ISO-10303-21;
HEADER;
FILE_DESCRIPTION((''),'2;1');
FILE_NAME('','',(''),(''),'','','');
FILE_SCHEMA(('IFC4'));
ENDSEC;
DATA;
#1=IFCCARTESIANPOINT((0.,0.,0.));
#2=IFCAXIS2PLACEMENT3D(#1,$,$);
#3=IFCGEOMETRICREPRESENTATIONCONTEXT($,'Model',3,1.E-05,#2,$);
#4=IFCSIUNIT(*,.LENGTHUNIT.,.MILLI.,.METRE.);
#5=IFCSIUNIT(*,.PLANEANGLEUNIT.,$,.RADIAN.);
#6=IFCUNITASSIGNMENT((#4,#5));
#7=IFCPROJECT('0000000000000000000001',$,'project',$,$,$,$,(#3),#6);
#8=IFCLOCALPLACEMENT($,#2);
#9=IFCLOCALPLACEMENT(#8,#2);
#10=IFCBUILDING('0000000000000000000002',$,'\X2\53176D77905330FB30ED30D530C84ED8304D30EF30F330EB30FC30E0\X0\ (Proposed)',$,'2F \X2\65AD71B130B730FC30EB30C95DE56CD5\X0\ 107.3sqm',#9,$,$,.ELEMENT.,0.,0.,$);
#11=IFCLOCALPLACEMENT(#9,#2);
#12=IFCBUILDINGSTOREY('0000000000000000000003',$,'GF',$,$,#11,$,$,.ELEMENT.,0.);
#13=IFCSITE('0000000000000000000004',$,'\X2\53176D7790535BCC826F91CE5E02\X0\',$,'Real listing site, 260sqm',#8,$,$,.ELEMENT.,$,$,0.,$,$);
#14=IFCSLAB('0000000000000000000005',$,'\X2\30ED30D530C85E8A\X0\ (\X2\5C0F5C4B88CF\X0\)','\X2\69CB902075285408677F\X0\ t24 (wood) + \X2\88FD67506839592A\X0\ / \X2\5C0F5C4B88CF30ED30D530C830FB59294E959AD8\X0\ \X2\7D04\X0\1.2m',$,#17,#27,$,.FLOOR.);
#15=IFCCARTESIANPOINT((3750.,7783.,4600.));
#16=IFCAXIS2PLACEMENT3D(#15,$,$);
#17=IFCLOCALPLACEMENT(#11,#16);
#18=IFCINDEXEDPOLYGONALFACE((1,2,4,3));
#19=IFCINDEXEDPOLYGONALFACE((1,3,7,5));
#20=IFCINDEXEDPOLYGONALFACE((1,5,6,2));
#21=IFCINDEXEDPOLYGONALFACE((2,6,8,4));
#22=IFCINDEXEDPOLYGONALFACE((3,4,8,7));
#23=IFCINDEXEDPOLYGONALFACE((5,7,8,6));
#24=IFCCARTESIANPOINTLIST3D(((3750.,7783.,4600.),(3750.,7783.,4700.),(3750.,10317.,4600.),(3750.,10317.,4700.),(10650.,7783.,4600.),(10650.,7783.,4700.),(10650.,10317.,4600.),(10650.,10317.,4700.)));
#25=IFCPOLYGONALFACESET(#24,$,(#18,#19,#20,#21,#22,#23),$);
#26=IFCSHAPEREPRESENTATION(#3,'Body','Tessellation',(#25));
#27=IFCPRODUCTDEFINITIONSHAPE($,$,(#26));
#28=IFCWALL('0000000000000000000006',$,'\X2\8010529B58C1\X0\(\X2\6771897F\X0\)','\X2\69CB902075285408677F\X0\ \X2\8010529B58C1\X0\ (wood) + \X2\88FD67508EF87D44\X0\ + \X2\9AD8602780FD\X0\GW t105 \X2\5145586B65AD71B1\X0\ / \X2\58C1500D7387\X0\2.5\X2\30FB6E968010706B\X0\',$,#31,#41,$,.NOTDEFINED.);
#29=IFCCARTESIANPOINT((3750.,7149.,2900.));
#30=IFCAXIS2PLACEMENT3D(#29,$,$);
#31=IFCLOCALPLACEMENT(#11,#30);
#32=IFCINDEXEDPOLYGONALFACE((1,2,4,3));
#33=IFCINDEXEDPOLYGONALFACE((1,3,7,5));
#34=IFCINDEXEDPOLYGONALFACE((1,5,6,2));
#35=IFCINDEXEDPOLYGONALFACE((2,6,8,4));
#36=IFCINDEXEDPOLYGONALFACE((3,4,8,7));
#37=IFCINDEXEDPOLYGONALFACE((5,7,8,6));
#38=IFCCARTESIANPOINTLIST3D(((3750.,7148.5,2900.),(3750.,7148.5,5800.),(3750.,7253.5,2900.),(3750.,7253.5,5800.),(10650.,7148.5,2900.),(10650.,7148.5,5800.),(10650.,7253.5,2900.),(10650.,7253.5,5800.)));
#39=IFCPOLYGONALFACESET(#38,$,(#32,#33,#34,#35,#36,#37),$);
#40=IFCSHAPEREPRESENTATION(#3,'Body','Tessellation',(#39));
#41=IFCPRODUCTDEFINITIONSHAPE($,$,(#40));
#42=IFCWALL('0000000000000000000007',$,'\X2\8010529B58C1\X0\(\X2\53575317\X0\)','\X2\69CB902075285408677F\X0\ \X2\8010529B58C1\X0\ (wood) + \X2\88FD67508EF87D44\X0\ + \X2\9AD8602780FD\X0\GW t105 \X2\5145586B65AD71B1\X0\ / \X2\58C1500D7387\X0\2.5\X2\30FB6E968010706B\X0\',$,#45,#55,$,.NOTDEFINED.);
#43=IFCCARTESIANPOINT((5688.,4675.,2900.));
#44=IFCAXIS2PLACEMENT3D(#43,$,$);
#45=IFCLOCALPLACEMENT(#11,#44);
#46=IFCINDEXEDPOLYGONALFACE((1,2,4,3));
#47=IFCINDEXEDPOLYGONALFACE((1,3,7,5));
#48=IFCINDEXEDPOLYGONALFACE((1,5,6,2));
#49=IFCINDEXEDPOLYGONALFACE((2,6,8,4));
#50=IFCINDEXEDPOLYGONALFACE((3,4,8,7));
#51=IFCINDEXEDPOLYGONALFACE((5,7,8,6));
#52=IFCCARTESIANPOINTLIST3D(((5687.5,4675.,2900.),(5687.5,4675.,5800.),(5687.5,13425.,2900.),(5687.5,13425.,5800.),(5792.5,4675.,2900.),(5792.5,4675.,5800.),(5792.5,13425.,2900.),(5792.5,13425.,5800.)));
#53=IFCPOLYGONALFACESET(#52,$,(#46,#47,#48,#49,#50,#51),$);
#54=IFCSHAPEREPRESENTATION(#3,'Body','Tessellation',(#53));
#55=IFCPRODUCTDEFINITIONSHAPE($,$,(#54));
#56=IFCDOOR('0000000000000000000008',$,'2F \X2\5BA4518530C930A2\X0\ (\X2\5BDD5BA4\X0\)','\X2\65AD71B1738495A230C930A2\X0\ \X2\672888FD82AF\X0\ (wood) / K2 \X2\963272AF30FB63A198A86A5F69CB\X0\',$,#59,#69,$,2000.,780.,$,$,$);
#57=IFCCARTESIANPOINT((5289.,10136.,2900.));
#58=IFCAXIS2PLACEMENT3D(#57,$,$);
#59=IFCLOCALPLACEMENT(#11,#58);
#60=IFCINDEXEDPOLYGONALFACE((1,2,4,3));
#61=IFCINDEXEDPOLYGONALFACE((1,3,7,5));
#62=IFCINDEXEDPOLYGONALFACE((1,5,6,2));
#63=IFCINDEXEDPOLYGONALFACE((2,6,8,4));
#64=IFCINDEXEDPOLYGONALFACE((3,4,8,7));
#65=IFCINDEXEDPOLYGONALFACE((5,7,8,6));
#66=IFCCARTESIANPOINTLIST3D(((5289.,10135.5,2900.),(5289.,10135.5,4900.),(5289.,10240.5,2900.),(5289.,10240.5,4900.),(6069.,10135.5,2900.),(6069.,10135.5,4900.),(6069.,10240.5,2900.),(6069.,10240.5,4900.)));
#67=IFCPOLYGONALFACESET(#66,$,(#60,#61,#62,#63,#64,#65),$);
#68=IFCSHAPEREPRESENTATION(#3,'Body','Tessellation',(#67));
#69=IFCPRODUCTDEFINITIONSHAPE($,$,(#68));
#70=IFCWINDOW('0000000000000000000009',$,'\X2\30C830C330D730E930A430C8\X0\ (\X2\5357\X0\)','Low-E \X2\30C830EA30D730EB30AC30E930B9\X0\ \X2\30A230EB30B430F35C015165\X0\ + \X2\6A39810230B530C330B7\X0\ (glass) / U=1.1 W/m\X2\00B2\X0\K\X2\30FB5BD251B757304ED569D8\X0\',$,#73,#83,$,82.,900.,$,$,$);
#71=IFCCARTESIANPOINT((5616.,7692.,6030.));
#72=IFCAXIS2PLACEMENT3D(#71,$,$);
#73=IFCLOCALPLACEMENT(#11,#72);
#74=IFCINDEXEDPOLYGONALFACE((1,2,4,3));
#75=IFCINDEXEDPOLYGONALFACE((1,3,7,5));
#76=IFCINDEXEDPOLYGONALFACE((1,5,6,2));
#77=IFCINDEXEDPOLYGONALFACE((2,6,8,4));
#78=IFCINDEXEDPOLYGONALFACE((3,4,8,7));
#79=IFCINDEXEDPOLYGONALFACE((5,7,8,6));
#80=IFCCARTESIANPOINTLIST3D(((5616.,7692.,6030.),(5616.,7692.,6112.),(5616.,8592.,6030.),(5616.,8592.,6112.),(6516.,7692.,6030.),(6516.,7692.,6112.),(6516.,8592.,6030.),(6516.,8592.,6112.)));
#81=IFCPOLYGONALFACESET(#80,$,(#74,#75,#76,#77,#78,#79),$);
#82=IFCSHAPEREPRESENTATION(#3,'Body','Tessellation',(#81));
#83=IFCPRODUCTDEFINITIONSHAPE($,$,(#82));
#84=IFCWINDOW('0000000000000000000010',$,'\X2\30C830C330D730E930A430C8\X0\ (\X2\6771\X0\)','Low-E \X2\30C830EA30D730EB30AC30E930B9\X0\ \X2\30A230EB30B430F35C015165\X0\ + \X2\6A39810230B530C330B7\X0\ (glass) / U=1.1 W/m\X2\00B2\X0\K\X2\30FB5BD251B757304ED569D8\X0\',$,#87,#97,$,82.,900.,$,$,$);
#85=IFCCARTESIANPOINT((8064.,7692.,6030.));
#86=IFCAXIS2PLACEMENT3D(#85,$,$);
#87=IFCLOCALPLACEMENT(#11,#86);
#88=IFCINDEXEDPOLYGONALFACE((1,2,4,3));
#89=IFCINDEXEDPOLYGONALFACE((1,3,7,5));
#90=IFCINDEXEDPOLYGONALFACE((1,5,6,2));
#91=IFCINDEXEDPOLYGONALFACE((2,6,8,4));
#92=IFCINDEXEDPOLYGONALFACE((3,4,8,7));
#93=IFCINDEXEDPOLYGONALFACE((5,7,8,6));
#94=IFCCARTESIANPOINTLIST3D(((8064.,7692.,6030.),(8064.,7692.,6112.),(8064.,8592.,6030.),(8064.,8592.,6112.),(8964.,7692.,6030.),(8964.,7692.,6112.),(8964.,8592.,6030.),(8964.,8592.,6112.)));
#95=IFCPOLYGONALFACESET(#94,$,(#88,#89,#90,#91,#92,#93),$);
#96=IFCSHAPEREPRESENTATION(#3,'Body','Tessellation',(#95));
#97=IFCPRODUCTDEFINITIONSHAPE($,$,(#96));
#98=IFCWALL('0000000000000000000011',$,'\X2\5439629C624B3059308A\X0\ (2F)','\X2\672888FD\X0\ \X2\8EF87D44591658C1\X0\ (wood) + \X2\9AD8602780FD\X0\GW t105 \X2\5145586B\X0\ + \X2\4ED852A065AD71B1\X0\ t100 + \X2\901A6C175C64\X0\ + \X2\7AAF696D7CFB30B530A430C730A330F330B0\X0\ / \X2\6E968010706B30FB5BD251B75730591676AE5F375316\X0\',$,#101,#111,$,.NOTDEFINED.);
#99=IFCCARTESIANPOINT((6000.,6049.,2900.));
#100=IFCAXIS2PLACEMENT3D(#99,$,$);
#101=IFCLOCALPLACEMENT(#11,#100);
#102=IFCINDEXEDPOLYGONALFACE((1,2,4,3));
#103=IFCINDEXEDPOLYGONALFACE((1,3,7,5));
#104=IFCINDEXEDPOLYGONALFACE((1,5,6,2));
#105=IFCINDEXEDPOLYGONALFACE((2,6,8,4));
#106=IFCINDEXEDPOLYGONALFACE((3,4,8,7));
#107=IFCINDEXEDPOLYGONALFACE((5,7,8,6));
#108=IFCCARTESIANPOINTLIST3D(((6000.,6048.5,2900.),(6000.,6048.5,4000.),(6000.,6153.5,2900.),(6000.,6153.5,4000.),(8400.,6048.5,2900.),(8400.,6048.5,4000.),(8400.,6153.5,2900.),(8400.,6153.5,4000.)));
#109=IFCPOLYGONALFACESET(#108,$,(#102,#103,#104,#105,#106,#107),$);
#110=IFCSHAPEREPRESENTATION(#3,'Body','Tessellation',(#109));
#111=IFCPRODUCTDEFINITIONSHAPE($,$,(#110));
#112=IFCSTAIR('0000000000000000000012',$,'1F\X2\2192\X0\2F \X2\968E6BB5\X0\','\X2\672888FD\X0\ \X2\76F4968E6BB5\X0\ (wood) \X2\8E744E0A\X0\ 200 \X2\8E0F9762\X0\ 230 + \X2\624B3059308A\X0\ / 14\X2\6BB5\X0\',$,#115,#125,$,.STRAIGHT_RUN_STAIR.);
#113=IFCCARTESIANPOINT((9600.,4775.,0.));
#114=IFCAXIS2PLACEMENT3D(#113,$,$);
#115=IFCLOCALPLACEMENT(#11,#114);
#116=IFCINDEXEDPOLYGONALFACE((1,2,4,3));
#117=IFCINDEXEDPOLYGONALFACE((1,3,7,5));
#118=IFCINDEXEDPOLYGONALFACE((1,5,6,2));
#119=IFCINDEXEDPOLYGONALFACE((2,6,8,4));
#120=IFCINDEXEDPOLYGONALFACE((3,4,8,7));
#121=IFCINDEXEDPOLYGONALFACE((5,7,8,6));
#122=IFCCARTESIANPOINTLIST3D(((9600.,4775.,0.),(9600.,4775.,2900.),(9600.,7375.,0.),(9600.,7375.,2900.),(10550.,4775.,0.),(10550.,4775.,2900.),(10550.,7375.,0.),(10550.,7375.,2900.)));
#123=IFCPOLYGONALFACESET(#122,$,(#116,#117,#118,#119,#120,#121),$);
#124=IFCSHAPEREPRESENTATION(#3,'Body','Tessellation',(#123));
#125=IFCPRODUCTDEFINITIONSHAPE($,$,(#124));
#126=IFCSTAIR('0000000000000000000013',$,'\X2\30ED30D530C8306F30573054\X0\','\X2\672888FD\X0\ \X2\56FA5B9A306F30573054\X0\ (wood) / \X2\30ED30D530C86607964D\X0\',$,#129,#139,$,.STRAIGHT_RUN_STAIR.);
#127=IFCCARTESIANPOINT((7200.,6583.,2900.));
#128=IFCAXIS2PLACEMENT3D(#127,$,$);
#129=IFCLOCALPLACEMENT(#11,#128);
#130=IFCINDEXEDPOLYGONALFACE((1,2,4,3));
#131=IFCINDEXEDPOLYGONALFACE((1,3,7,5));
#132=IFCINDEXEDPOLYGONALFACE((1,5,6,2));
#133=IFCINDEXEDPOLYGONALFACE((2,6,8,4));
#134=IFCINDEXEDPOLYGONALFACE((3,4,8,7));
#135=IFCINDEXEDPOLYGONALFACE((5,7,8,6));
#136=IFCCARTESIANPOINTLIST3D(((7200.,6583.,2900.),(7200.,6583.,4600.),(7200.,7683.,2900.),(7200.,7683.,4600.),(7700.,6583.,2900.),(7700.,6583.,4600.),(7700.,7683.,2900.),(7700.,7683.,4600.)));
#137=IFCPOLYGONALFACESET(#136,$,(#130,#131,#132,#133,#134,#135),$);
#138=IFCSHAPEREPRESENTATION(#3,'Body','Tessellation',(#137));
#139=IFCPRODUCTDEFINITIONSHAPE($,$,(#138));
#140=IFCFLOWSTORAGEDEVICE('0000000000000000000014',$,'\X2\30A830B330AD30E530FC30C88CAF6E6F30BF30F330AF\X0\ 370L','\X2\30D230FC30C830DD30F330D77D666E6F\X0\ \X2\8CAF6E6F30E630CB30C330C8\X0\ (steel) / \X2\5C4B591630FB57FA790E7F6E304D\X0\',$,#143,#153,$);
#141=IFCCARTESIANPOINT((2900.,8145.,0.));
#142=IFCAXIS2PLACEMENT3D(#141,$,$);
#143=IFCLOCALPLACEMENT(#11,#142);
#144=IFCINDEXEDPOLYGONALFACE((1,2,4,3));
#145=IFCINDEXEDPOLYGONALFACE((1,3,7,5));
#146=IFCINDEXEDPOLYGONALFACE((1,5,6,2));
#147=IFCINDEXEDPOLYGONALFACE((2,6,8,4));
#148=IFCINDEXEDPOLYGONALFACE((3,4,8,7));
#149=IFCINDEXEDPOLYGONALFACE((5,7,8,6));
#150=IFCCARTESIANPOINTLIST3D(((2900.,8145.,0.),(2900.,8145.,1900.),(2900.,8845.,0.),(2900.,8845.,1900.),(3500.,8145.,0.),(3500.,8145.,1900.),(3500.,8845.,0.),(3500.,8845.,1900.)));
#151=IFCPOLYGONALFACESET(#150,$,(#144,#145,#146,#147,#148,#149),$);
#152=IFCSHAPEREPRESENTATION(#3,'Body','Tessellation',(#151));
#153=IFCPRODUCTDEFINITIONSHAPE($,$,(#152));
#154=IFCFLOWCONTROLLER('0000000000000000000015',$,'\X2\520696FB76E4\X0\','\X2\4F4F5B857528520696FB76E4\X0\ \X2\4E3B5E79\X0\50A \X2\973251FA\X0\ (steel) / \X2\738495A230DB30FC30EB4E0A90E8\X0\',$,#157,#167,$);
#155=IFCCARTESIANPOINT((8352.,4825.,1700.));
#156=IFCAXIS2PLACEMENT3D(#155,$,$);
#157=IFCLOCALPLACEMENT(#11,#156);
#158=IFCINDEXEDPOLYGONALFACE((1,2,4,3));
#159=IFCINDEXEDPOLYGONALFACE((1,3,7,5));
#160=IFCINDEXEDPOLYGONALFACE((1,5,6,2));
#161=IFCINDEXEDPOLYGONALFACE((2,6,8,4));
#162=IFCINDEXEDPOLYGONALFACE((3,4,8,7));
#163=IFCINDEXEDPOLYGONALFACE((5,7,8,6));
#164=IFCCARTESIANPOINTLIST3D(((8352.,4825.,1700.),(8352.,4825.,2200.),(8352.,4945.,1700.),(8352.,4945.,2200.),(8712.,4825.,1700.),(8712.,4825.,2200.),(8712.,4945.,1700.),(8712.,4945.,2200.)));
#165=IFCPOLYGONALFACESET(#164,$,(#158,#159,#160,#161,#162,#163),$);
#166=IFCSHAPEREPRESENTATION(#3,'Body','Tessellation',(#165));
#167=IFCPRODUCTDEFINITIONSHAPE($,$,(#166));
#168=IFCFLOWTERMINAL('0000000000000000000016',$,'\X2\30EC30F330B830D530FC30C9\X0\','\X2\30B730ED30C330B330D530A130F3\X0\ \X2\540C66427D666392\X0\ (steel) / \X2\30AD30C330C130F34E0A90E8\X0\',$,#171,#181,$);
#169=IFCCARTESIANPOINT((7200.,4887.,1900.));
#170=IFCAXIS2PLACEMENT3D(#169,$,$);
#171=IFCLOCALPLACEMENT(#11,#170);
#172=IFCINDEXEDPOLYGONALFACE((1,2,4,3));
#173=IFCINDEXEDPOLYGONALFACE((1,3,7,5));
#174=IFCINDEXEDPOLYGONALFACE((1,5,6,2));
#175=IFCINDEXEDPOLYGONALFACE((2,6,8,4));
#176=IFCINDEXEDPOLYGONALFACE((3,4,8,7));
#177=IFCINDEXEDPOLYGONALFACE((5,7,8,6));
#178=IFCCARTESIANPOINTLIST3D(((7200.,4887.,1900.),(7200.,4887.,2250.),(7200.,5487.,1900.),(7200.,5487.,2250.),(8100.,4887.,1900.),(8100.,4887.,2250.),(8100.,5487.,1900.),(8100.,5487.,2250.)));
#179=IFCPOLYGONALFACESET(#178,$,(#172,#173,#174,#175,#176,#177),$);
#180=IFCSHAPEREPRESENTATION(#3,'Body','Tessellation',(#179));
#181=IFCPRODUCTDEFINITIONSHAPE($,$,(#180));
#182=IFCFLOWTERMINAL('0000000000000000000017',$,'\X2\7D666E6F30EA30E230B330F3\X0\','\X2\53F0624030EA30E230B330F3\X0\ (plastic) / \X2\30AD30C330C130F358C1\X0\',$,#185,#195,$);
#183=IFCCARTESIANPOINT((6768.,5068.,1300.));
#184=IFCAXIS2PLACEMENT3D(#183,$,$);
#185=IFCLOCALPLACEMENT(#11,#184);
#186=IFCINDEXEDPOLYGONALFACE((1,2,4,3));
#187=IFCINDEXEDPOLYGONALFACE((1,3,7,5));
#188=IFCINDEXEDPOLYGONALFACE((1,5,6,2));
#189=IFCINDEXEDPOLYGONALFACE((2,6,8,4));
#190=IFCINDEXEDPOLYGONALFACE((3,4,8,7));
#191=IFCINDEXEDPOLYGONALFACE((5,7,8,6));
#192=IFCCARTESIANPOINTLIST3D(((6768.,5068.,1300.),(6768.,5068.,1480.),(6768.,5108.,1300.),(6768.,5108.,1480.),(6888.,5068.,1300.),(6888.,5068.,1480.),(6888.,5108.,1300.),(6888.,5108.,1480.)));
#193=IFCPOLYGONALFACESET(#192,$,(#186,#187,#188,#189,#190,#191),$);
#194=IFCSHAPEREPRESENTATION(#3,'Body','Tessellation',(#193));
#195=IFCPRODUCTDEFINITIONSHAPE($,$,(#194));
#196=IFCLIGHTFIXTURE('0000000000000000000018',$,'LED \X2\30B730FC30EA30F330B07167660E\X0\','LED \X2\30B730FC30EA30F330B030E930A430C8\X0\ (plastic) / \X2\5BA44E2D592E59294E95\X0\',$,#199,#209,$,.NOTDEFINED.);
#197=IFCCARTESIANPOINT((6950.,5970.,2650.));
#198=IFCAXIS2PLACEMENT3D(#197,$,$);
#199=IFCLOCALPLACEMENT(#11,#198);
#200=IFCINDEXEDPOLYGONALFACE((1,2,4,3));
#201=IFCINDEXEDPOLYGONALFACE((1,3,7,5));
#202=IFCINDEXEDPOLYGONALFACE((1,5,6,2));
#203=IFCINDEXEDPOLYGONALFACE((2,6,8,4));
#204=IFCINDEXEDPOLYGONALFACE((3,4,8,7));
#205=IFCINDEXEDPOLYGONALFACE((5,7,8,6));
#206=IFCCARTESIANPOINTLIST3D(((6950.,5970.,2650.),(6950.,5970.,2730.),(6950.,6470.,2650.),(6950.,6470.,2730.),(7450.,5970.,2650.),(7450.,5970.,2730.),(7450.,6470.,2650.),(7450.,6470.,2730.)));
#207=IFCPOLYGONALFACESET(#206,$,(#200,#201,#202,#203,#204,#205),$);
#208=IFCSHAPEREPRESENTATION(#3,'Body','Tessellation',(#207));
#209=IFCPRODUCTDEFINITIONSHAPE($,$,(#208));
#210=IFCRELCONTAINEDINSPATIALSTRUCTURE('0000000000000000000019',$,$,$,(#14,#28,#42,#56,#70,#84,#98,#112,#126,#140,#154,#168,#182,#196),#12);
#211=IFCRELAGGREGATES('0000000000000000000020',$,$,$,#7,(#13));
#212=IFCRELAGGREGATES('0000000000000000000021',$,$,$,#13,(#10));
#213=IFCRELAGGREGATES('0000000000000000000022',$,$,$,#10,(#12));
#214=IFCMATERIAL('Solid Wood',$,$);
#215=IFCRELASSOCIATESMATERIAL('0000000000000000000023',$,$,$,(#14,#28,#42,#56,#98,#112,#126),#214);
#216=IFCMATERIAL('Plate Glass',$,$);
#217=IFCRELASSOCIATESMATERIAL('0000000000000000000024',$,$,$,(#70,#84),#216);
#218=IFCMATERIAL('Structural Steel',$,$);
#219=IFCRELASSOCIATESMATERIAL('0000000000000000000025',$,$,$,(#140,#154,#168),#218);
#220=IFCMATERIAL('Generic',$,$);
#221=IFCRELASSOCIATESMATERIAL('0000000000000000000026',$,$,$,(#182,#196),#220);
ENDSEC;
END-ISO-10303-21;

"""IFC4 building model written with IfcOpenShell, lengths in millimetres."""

from ifc_helpers import new_model, si_unit, frame, frame_2d, origin, place, context, project, spatial, rectangle, extrude, material, element, fill, save


model = new_model("IFC4")

# Units and contexts
model_context = context("Model", 3, precision=1e-05, world=origin())
ifc_project = project(units=[si_unit("LENGTHUNIT", "METRE", prefix="MILLI"), si_unit("PLANEANGLEUNIT", "RADIAN")], contexts=[model_context])

# Site, building, storey
site_placement = place(None, origin())
site = spatial("IfcSite", under=ifc_project, at=site_placement, Name="北海道富良野市", ObjectType="Real listing site, 260sqm", CompositionType="ELEMENT", RefElevation=0.0)
building_placement = place(site_placement, origin())
building = spatial("IfcBuilding", under=site, at=building_placement, Name="北海道・ロフト付きワンルーム (Proposed)", ObjectType="2F 断熱シールド工法 107.3sqm", CompositionType="ELEMENT", ElevationOfRefHeight=0.0, ElevationOfTerrain=0.0)
storey_placement = place(building_placement, origin())
storey = spatial("IfcBuildingStorey", under=building, at=storey_placement, Name="GF", CompositionType="ELEMENT", Elevation=0.0)

# Shared definitions
ifc_material_1 = material(Name="Solid Wood")

# Slab
slab_placement = place(storey_placement, frame((3750.0, 7783.0, 4600.0)))
element("IfcSlab", 1, at=slab_placement, inside=storey, material=ifc_material_1, Name="ロフト床 (小屋裏)", Description="構造用合板 t24 (wood) + 製材根太 / 小屋裏ロフト・天井高 約1.2m", PredefinedType="FLOOR", context=model_context, shape_type="SweptSolid", body=[
    extrude(rectangle(XDim=6900.0, YDim=2534.0, at=frame_2d((3450.0, 1267.0))), frame((3750.0, 7783.0, 4600.0)), (0.0, 0.0, 1.0), 100.0),
])

# Wall
wall_1_placement = place(storey_placement, frame((3750.0, 7149.0, 2900.0)))
element("IfcWall", 2, at=wall_1_placement, inside=storey, material=ifc_material_1, Name="耐力壁(東西)", Description="構造用合板 耐力壁 (wood) + 製材軸組 + 高性能GW t105 充填断熱 / 壁倍率2.5・準耐火", PredefinedType="NOTDEFINED", context=model_context, shape_type="SweptSolid", body=[
    extrude(rectangle(XDim=6900.0, YDim=105.0, at=frame_2d((3450.0, 52.0))), frame((3750.0, 7149.0, 2900.0)), (0.0, 0.0, 1.0), 2900.0),
])

# Wall, opening, door
wall_2_placement = place(storey_placement, frame((5688.0, 4675.0, 2900.0)))
wall_2 = element("IfcWall", 3, at=wall_2_placement, inside=storey, material=ifc_material_1, Name="耐力壁(南北)", Description="構造用合板 耐力壁 (wood) + 製材軸組 + 高性能GW t105 充填断熱 / 壁倍率2.5・準耐火", PredefinedType="NOTDEFINED", context=model_context, shape_type="SweptSolid", body=[
    extrude(rectangle(XDim=105.0, YDim=8750.0, at=frame_2d((52.0, 4375.0))), frame((5688.0, 4675.0, 2900.0)), (0.0, 0.0, 1.0), 2900.0),
])
opening_placement = place(storey_placement, frame((5289.0, 10136.0, 2900.0)))
opening = element("IfcOpeningElement", 4, at=opening_placement, cuts=wall_2, PredefinedType="NOTDEFINED", context=model_context, shape_type="SweptSolid", body=[
    extrude(rectangle(XDim=780.0, YDim=105.0, at=frame_2d((390.0, 52.0))), frame((5289.0, 10136.0, 2900.0)), (0.0, 0.0, 1.0), 2000.0),
])
door_placement = place(storey_placement, frame((5289.0, 10136.0, 2900.0)))
door = element("IfcDoor", 5, at=door_placement, inside=storey, material=ifc_material_1, Name="2F 室内ドア (寝室)", Description="断熱玄関ドア 木製芯 (wood) / K2 防犯・採風機構", OverallHeight=2000.0, OverallWidth=780.0, context=model_context, shape_type="SweptSolid", body=[
    extrude(rectangle(XDim=780.0, YDim=105.0, at=frame_2d((390.0, 52.0))), frame((5289.0, 10136.0, 2900.0)), (0.0, 0.0, 1.0), 2000.0),
])
fill(opening, door)

# Windows
ifc_material_2 = material(Name="Plate Glass")
window_1_placement = place(storey_placement, frame((5616.0, 7692.0, 6030.0)))
element("IfcWindow", 6, at=window_1_placement, inside=storey, material=ifc_material_2, Name="トップライト (南)", Description="Low-E トリプルガラス アルゴン封入 + 樹脂サッシ (glass) / U=1.1 W/m²K・寒冷地仕様", OverallHeight=82.0, OverallWidth=900.0, context=model_context, shape_type="SweptSolid", body=[
    extrude(rectangle(XDim=900.0, YDim=900.0, at=frame_2d((450.0, 450.0))), frame((5616.0, 7692.0, 6030.0)), (0.0, 0.0, 1.0), 82.0),
])
window_2_placement = place(storey_placement, frame((8064.0, 7692.0, 6030.0)))
element("IfcWindow", 7, at=window_2_placement, inside=storey, material=ifc_material_2, Name="トップライト (東)", Description="Low-E トリプルガラス アルゴン封入 + 樹脂サッシ (glass) / U=1.1 W/m²K・寒冷地仕様", OverallHeight=82.0, OverallWidth=900.0, context=model_context, shape_type="SweptSolid", body=[
    extrude(rectangle(XDim=900.0, YDim=900.0, at=frame_2d((450.0, 450.0))), frame((8064.0, 7692.0, 6030.0)), (0.0, 0.0, 1.0), 82.0),
])

# Wall
wall_3_placement = place(storey_placement, frame((6000.0, 6049.0, 2900.0)))
element("IfcWall", 8, at=wall_3_placement, inside=storey, material=ifc_material_1, Name="吹抜手すり (2F)", Description="木製 軸組外壁 (wood) + 高性能GW t105 充填 + 付加断熱 t100 + 通気層 + 窯業系サイディング / 準耐火・寒冷地外皮強化", PredefinedType="NOTDEFINED", context=model_context, shape_type="SweptSolid", body=[
    extrude(rectangle(XDim=2400.0, YDim=105.0, at=frame_2d((1200.0, 52.0))), frame((6000.0, 6049.0, 2900.0)), (0.0, 0.0, 1.0), 1100.0),
])

# Stairs
stair_1_placement = place(storey_placement, frame((9600.0, 4775.0, 0.0)))
element("IfcStair", 9, at=stair_1_placement, inside=storey, material=ifc_material_1, Name="1F→2F 階段", Description="木製 直階段 (wood) 蹴上 200 踏面 230 + 手すり / 14段", PredefinedType="STRAIGHT_RUN_STAIR", context=model_context, shape_type="SweptSolid", body=[
    extrude(rectangle(XDim=950.0, YDim=2600.0, at=frame_2d((475.0, 1300.0))), frame((9600.0, 4775.0, 0.0)), (0.0, 0.0, 1.0), 2900.0),
])
stair_2_placement = place(storey_placement, frame((7200.0, 6583.0, 2900.0)))
element("IfcStair", 10, at=stair_2_placement, inside=storey, material=ifc_material_1, Name="ロフトはしご", Description="木製 固定はしご (wood) / ロフト昇降", PredefinedType="STRAIGHT_RUN_STAIR", context=model_context, shape_type="SweptSolid", body=[
    extrude(rectangle(XDim=500.0, YDim=1100.0, at=frame_2d((250.0, 550.0))), frame((7200.0, 6583.0, 2900.0)), (0.0, 0.0, 1.0), 1700.0),
])

# Flow storage device
ifc_material_3 = material(Name="Structural Steel")
flow_storage_device_placement = place(storey_placement, frame((2900.0, 8145.0, 0.0)))
element("IfcFlowStorageDevice", 11, at=flow_storage_device_placement, inside=storey, material=ifc_material_3, Name="エコキュート貯湯タンク 370L", Description="ヒートポンプ給湯 貯湯ユニット (steel) / 屋外・基礎置き", context=model_context, shape_type="SweptSolid", body=[
    extrude(rectangle(XDim=600.0, YDim=700.0, at=frame_2d((300.0, 350.0))), frame((2900.0, 8145.0, 0.0)), (0.0, 0.0, 1.0), 1900.0),
])

# Flow controller
flow_controller_placement = place(storey_placement, frame((8352.0, 4825.0, 1700.0)))
element("IfcFlowController", 12, at=flow_controller_placement, inside=storey, material=ifc_material_3, Name="分電盤", Description="住宅用分電盤 主幹50A 露出 (steel) / 玄関ホール上部", context=model_context, shape_type="SweptSolid", body=[
    extrude(rectangle(XDim=360.0, YDim=120.0, at=frame_2d((180.0, 60.0))), frame((8352.0, 4825.0, 1700.0)), (0.0, 0.0, 1.0), 500.0),
])

# Flow terminals
flow_terminal_1_placement = place(storey_placement, frame((7200.0, 4887.0, 1900.0)))
element("IfcFlowTerminal", 13, at=flow_terminal_1_placement, inside=storey, material=ifc_material_3, Name="レンジフード", Description="シロッコファン 同時給排 (steel) / キッチン上部", context=model_context, shape_type="SweptSolid", body=[
    extrude(rectangle(XDim=900.0, YDim=600.0, at=frame_2d((450.0, 300.0))), frame((7200.0, 4887.0, 1900.0)), (0.0, 0.0, 1.0), 350.0),
])
ifc_material_4 = material(Name="Generic")
flow_terminal_2_placement = place(storey_placement, frame((6768.0, 5068.0, 1300.0)))
element("IfcFlowTerminal", 14, at=flow_terminal_2_placement, inside=storey, material=ifc_material_4, Name="給湯リモコン", Description="台所リモコン (plastic) / キッチン壁", context=model_context, shape_type="SweptSolid", body=[
    extrude(rectangle(XDim=120.0, YDim=40.0, at=frame_2d((60.0, 20.0))), frame((6768.0, 5068.0, 1300.0)), (0.0, 0.0, 1.0), 180.0),
])

# Light fixture
light_fixture_1_placement = place(storey_placement, frame((6950.0, 5970.0, 2650.0)))
element("IfcLightFixture", 15, at=light_fixture_1_placement, inside=storey, material=ifc_material_4, Name="LED シーリング照明", Description="LED シーリングライト (plastic) / 室中央天井", PredefinedType="NOTDEFINED", context=model_context, shape_type="SweptSolid", body=[
    extrude(rectangle(XDim=500.0, YDim=500.0, at=frame_2d((250.0, 250.0))), frame((6950.0, 5970.0, 2650.0)), (0.0, 0.0, 1.0), 80.0),
])

save(model, "model.ifc")
